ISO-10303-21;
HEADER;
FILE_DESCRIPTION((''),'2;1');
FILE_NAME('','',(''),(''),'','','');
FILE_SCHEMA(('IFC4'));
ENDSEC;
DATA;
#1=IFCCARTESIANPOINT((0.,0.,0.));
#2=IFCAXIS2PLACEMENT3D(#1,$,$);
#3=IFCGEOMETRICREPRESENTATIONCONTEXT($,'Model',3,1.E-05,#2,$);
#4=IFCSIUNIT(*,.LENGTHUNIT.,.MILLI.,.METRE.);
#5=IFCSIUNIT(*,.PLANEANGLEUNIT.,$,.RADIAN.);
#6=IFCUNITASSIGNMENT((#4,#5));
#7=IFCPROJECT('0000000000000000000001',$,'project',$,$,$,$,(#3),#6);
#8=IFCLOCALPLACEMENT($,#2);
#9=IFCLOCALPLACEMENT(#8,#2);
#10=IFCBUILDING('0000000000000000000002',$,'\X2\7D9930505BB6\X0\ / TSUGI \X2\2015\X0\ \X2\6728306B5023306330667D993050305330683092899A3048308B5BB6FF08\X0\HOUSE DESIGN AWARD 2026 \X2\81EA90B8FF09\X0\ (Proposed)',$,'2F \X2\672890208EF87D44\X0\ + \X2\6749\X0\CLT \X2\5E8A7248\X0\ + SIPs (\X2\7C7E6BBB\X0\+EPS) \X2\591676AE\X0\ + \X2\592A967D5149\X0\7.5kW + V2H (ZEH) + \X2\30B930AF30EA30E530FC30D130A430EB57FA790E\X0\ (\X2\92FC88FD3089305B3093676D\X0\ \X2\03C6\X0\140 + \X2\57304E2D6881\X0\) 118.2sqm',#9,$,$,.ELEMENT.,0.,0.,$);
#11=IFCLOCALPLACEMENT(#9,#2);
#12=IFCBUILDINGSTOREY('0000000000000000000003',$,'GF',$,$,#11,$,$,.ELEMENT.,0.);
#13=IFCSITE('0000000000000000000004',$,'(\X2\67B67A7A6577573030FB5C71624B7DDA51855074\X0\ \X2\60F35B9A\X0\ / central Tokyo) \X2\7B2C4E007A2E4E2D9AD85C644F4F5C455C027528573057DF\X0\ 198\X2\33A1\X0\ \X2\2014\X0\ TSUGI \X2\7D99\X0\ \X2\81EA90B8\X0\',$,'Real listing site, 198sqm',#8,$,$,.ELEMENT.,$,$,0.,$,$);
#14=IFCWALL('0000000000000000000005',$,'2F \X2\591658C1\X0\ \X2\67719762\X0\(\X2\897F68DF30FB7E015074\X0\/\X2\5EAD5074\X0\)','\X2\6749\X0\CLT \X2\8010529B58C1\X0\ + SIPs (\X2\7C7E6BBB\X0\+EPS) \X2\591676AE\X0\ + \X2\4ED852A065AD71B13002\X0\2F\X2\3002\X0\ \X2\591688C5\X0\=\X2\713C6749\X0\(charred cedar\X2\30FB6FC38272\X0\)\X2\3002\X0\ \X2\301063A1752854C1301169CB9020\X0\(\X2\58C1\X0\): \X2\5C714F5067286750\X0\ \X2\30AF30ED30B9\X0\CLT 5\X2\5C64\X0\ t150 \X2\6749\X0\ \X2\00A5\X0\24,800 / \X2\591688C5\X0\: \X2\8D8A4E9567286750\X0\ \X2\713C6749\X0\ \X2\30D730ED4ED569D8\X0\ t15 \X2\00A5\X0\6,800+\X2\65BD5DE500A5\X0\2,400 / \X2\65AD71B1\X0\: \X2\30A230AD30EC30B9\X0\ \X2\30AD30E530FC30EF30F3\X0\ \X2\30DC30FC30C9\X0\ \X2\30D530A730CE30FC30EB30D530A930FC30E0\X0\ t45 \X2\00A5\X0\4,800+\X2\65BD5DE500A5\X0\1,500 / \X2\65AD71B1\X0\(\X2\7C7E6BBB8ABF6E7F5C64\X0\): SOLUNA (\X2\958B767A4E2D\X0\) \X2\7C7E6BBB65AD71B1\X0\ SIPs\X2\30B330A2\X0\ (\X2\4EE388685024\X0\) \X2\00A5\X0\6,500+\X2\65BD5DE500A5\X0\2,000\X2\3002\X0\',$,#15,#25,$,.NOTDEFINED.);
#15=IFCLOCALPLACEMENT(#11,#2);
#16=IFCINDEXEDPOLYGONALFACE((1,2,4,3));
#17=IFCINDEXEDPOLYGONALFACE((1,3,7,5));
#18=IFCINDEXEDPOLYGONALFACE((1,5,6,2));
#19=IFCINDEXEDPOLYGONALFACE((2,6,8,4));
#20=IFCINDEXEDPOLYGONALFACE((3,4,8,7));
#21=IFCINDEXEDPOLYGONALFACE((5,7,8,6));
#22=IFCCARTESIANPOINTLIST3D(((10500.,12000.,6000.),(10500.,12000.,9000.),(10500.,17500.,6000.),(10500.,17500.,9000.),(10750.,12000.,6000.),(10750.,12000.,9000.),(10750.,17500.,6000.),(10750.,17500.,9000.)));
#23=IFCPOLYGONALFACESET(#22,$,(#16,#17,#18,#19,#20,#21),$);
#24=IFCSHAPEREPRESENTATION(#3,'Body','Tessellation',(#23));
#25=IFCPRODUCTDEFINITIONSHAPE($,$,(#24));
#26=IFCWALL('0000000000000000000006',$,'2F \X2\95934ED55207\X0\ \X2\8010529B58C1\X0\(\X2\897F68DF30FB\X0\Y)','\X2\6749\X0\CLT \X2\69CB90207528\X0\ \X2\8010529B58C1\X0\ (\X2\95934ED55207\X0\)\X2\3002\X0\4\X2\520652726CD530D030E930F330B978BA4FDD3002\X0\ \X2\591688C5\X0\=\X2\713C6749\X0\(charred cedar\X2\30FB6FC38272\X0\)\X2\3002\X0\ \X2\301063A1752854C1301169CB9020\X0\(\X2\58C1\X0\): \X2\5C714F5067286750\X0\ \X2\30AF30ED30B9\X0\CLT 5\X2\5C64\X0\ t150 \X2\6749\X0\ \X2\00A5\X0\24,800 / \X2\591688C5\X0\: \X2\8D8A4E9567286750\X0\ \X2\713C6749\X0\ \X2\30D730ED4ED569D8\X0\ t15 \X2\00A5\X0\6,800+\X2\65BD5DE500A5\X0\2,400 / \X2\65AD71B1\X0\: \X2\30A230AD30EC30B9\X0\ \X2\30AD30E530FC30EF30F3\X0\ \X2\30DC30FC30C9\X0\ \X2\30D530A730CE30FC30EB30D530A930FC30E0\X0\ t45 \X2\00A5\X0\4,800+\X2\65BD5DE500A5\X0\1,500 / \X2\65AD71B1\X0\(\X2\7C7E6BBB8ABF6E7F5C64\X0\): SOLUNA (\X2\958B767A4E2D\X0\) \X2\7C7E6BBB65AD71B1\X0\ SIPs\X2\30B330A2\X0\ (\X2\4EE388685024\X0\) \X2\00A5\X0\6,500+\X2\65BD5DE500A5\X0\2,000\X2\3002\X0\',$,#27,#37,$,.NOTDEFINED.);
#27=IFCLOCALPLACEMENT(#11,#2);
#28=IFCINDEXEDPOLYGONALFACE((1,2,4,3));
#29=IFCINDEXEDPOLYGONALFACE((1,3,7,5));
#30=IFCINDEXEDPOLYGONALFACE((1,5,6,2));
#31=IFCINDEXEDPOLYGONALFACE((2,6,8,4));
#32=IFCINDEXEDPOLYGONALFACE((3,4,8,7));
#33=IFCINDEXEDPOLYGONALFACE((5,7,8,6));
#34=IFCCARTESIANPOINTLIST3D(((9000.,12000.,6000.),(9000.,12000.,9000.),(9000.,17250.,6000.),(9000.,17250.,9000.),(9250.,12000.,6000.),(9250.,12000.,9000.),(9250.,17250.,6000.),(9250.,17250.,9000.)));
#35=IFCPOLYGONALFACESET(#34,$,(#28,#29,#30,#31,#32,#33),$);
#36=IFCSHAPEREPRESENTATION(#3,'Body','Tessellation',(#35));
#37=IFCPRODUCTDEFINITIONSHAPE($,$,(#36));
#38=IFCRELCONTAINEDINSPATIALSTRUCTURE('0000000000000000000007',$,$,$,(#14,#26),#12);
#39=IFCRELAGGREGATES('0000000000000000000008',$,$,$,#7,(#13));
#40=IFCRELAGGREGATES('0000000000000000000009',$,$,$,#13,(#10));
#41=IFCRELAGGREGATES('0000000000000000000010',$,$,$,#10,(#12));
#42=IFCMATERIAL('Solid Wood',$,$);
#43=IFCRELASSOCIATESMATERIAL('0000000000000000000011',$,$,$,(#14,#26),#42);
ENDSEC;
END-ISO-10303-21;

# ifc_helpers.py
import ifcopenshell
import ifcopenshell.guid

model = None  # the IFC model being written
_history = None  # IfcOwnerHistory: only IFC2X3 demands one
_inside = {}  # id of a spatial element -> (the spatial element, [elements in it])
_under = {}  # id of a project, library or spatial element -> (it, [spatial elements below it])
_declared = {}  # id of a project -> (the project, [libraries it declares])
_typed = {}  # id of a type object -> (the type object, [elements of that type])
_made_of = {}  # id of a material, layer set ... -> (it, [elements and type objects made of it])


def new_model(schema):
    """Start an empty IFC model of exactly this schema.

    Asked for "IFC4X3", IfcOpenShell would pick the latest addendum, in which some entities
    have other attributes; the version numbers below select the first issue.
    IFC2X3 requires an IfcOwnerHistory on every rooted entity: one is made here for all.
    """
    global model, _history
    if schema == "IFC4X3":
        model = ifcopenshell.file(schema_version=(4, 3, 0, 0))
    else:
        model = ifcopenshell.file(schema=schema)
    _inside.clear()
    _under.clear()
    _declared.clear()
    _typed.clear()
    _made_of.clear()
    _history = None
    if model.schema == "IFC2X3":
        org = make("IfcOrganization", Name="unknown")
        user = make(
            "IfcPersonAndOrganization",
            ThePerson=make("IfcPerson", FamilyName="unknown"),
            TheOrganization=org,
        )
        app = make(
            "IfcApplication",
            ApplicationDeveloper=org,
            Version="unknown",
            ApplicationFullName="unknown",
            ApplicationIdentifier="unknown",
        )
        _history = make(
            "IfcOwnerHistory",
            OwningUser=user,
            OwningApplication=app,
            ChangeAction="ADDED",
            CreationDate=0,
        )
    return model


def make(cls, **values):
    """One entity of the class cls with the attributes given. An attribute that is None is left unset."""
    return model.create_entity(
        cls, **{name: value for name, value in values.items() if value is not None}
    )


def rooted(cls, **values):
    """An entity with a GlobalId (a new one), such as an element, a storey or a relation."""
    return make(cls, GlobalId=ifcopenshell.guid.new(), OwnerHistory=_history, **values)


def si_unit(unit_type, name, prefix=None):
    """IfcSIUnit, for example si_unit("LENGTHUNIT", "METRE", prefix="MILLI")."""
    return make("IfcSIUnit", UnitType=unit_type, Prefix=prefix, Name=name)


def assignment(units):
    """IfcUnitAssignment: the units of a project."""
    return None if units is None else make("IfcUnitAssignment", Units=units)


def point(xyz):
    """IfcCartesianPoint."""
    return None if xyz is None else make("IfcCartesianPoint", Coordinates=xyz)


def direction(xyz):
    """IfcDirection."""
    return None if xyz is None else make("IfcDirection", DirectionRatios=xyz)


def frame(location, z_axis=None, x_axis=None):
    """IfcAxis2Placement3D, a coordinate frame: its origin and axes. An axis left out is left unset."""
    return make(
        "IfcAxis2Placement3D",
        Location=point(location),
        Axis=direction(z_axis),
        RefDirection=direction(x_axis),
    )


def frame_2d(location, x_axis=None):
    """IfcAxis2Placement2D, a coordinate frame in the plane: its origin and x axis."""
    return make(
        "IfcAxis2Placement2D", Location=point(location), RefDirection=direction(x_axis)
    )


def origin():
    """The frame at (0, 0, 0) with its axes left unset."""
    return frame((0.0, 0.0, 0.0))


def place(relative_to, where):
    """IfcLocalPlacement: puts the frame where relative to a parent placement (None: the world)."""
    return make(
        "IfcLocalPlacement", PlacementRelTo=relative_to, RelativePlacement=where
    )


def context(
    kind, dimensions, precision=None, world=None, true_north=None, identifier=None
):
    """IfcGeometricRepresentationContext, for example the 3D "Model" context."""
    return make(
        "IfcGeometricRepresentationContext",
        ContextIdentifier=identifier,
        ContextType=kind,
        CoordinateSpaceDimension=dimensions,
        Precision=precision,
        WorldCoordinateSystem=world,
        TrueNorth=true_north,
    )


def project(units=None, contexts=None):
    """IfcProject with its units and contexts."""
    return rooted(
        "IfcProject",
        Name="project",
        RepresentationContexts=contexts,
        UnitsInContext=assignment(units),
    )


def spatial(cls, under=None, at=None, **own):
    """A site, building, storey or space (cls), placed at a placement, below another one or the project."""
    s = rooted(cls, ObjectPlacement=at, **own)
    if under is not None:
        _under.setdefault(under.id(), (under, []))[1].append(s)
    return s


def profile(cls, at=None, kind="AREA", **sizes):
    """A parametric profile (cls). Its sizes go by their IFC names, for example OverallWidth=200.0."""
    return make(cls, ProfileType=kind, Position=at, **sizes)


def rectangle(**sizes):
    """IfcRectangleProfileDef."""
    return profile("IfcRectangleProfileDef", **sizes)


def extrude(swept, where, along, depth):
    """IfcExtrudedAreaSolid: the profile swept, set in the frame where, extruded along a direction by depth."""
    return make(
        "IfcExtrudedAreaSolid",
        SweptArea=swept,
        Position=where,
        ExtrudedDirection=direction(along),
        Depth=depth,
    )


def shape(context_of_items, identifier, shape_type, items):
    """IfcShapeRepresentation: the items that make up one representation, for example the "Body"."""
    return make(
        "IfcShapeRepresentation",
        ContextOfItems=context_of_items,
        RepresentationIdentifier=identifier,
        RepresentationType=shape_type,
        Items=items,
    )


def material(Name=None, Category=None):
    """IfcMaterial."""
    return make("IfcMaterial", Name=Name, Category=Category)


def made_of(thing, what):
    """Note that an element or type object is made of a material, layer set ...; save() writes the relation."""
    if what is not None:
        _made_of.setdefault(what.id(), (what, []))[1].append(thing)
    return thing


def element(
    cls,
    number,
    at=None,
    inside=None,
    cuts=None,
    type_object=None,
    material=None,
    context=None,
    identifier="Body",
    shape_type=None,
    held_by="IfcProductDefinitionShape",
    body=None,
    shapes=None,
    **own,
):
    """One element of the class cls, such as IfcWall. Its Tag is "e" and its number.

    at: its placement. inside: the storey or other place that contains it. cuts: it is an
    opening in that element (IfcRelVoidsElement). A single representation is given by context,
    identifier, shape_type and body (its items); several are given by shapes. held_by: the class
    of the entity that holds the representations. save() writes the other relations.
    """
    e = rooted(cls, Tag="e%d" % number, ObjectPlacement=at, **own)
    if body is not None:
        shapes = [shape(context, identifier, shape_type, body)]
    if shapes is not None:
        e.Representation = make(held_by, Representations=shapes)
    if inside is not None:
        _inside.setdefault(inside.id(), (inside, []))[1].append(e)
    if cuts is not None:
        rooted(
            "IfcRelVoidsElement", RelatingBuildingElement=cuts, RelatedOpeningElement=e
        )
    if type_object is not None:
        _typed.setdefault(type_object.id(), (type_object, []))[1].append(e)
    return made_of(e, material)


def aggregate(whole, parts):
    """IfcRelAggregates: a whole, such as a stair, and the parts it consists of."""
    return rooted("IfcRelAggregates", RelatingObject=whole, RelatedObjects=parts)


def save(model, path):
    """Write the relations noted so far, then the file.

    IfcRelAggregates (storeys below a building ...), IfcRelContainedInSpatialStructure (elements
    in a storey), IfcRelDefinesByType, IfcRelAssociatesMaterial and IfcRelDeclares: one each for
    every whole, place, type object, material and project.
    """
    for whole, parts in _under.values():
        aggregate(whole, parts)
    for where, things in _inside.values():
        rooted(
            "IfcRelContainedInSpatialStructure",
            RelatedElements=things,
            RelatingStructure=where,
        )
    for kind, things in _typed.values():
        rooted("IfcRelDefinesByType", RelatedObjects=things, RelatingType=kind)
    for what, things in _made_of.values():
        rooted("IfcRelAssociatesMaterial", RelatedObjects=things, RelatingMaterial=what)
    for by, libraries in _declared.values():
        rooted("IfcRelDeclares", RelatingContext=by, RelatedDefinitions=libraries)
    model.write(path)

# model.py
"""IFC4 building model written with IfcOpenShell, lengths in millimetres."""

from ifc_helpers import new_model, si_unit, frame, frame_2d, origin, place, context, project, spatial, rectangle, extrude, material, element, save


model = new_model("IFC4")

# Units and contexts
model_context = context("Model", 3, precision=1e-05, world=origin())
ifc_project = project(units=[si_unit("LENGTHUNIT", "METRE", prefix="MILLI"), si_unit("PLANEANGLEUNIT", "RADIAN")], contexts=[model_context])

# Site, building, storey
site_placement = place(None, origin())
site = spatial("IfcSite", under=ifc_project, at=site_placement, Name="(架空敷地・山手線内側 想定 / central Tokyo) 第一種中高層住居専用地域 198㎡ — TSUGI 継 自邸", ObjectType="Real listing site, 198sqm", CompositionType="ELEMENT", RefElevation=0.0)
building_placement = place(site_placement, origin())
building = spatial("IfcBuilding", under=site, at=building_placement, Name="継ぐ家 / TSUGI ― 木に倣って継ぐことを覚える家（HOUSE DESIGN AWARD 2026 自邸） (Proposed)", ObjectType="2F 木造軸組 + 杉CLT 床版 + SIPs (籾殻+EPS) 外皮 + 太陽光7.5kW + V2H (ZEH) + スクリューパイル基礎 (鋼製らせん杭 φ140 + 地中梁) 118.2sqm", CompositionType="ELEMENT", ElevationOfRefHeight=0.0, ElevationOfTerrain=0.0)
storey_placement = place(building_placement, origin())
storey = spatial("IfcBuildingStorey", under=building, at=storey_placement, Name="GF", CompositionType="ELEMENT", Elevation=0.0)

# Shared definitions
ifc_material_1 = material(Name="Solid Wood")

# Walls
wall_1_placement = place(storey_placement, frame((5250.0, 6000.0, 3000.0)))
element("IfcWall", 1, at=wall_1_placement, inside=storey, material=ifc_material_1, Name="2F 外壁 東面(西棟・縁側/庭側)", Description="杉CLT 耐力壁 + SIPs (籾殻+EPS) 外皮 + 付加断熱。2F。 外装=焼杉(charred cedar・濃色)。 【採用品】構造(壁): 山佐木材 クロスCLT 5層 t150 杉 ¥24,800 / 外装: 越井木材 焼杉 プロ仕様 t15 ¥6,800+施工¥2,400 / 断熱: アキレス キューワン ボード フェノールフォーム t45 ¥4,800+施工¥1,500 / 断熱(籾殻調湿層): SOLUNA (開発中) 籾殻断熱 SIPsコア (代表値) ¥6,500+施工¥2,000。", PredefinedType="NOTDEFINED", context=model_context, shape_type="SweptSolid", body=[
    extrude(rectangle(XDim=250.0, YDim=5500.0, at=frame_2d((125.0, 2750.0))), frame((5250.0, 6000.0, 3000.0)), (0.0, 0.0, 1.0), 3000.0),
])
wall_2_placement = place(storey_placement, frame((4500.0, 6000.0, 3000.0)))
element("IfcWall", 2, at=wall_2_placement, inside=storey, material=ifc_material_1, Name="2F 間仕切 耐力壁(西棟・Y)", Description="杉CLT 構造用 耐力壁 (間仕切)。4分割法バランス確保。 外装=焼杉(charred cedar・濃色)。 【採用品】構造(壁): 山佐木材 クロスCLT 5層 t150 杉 ¥24,800 / 外装: 越井木材 焼杉 プロ仕様 t15 ¥6,800+施工¥2,400 / 断熱: アキレス キューワン ボード フェノールフォーム t45 ¥4,800+施工¥1,500 / 断熱(籾殻調湿層): SOLUNA (開発中) 籾殻断熱 SIPsコア (代表値) ¥6,500+施工¥2,000。", PredefinedType="NOTDEFINED", context=model_context, shape_type="SweptSolid", body=[
    extrude(rectangle(XDim=250.0, YDim=5250.0, at=frame_2d((125.0, 2625.0))), frame((4500.0, 6000.0, 3000.0)), (0.0, 0.0, 1.0), 3000.0),
])

save(model, "model.ifc")
